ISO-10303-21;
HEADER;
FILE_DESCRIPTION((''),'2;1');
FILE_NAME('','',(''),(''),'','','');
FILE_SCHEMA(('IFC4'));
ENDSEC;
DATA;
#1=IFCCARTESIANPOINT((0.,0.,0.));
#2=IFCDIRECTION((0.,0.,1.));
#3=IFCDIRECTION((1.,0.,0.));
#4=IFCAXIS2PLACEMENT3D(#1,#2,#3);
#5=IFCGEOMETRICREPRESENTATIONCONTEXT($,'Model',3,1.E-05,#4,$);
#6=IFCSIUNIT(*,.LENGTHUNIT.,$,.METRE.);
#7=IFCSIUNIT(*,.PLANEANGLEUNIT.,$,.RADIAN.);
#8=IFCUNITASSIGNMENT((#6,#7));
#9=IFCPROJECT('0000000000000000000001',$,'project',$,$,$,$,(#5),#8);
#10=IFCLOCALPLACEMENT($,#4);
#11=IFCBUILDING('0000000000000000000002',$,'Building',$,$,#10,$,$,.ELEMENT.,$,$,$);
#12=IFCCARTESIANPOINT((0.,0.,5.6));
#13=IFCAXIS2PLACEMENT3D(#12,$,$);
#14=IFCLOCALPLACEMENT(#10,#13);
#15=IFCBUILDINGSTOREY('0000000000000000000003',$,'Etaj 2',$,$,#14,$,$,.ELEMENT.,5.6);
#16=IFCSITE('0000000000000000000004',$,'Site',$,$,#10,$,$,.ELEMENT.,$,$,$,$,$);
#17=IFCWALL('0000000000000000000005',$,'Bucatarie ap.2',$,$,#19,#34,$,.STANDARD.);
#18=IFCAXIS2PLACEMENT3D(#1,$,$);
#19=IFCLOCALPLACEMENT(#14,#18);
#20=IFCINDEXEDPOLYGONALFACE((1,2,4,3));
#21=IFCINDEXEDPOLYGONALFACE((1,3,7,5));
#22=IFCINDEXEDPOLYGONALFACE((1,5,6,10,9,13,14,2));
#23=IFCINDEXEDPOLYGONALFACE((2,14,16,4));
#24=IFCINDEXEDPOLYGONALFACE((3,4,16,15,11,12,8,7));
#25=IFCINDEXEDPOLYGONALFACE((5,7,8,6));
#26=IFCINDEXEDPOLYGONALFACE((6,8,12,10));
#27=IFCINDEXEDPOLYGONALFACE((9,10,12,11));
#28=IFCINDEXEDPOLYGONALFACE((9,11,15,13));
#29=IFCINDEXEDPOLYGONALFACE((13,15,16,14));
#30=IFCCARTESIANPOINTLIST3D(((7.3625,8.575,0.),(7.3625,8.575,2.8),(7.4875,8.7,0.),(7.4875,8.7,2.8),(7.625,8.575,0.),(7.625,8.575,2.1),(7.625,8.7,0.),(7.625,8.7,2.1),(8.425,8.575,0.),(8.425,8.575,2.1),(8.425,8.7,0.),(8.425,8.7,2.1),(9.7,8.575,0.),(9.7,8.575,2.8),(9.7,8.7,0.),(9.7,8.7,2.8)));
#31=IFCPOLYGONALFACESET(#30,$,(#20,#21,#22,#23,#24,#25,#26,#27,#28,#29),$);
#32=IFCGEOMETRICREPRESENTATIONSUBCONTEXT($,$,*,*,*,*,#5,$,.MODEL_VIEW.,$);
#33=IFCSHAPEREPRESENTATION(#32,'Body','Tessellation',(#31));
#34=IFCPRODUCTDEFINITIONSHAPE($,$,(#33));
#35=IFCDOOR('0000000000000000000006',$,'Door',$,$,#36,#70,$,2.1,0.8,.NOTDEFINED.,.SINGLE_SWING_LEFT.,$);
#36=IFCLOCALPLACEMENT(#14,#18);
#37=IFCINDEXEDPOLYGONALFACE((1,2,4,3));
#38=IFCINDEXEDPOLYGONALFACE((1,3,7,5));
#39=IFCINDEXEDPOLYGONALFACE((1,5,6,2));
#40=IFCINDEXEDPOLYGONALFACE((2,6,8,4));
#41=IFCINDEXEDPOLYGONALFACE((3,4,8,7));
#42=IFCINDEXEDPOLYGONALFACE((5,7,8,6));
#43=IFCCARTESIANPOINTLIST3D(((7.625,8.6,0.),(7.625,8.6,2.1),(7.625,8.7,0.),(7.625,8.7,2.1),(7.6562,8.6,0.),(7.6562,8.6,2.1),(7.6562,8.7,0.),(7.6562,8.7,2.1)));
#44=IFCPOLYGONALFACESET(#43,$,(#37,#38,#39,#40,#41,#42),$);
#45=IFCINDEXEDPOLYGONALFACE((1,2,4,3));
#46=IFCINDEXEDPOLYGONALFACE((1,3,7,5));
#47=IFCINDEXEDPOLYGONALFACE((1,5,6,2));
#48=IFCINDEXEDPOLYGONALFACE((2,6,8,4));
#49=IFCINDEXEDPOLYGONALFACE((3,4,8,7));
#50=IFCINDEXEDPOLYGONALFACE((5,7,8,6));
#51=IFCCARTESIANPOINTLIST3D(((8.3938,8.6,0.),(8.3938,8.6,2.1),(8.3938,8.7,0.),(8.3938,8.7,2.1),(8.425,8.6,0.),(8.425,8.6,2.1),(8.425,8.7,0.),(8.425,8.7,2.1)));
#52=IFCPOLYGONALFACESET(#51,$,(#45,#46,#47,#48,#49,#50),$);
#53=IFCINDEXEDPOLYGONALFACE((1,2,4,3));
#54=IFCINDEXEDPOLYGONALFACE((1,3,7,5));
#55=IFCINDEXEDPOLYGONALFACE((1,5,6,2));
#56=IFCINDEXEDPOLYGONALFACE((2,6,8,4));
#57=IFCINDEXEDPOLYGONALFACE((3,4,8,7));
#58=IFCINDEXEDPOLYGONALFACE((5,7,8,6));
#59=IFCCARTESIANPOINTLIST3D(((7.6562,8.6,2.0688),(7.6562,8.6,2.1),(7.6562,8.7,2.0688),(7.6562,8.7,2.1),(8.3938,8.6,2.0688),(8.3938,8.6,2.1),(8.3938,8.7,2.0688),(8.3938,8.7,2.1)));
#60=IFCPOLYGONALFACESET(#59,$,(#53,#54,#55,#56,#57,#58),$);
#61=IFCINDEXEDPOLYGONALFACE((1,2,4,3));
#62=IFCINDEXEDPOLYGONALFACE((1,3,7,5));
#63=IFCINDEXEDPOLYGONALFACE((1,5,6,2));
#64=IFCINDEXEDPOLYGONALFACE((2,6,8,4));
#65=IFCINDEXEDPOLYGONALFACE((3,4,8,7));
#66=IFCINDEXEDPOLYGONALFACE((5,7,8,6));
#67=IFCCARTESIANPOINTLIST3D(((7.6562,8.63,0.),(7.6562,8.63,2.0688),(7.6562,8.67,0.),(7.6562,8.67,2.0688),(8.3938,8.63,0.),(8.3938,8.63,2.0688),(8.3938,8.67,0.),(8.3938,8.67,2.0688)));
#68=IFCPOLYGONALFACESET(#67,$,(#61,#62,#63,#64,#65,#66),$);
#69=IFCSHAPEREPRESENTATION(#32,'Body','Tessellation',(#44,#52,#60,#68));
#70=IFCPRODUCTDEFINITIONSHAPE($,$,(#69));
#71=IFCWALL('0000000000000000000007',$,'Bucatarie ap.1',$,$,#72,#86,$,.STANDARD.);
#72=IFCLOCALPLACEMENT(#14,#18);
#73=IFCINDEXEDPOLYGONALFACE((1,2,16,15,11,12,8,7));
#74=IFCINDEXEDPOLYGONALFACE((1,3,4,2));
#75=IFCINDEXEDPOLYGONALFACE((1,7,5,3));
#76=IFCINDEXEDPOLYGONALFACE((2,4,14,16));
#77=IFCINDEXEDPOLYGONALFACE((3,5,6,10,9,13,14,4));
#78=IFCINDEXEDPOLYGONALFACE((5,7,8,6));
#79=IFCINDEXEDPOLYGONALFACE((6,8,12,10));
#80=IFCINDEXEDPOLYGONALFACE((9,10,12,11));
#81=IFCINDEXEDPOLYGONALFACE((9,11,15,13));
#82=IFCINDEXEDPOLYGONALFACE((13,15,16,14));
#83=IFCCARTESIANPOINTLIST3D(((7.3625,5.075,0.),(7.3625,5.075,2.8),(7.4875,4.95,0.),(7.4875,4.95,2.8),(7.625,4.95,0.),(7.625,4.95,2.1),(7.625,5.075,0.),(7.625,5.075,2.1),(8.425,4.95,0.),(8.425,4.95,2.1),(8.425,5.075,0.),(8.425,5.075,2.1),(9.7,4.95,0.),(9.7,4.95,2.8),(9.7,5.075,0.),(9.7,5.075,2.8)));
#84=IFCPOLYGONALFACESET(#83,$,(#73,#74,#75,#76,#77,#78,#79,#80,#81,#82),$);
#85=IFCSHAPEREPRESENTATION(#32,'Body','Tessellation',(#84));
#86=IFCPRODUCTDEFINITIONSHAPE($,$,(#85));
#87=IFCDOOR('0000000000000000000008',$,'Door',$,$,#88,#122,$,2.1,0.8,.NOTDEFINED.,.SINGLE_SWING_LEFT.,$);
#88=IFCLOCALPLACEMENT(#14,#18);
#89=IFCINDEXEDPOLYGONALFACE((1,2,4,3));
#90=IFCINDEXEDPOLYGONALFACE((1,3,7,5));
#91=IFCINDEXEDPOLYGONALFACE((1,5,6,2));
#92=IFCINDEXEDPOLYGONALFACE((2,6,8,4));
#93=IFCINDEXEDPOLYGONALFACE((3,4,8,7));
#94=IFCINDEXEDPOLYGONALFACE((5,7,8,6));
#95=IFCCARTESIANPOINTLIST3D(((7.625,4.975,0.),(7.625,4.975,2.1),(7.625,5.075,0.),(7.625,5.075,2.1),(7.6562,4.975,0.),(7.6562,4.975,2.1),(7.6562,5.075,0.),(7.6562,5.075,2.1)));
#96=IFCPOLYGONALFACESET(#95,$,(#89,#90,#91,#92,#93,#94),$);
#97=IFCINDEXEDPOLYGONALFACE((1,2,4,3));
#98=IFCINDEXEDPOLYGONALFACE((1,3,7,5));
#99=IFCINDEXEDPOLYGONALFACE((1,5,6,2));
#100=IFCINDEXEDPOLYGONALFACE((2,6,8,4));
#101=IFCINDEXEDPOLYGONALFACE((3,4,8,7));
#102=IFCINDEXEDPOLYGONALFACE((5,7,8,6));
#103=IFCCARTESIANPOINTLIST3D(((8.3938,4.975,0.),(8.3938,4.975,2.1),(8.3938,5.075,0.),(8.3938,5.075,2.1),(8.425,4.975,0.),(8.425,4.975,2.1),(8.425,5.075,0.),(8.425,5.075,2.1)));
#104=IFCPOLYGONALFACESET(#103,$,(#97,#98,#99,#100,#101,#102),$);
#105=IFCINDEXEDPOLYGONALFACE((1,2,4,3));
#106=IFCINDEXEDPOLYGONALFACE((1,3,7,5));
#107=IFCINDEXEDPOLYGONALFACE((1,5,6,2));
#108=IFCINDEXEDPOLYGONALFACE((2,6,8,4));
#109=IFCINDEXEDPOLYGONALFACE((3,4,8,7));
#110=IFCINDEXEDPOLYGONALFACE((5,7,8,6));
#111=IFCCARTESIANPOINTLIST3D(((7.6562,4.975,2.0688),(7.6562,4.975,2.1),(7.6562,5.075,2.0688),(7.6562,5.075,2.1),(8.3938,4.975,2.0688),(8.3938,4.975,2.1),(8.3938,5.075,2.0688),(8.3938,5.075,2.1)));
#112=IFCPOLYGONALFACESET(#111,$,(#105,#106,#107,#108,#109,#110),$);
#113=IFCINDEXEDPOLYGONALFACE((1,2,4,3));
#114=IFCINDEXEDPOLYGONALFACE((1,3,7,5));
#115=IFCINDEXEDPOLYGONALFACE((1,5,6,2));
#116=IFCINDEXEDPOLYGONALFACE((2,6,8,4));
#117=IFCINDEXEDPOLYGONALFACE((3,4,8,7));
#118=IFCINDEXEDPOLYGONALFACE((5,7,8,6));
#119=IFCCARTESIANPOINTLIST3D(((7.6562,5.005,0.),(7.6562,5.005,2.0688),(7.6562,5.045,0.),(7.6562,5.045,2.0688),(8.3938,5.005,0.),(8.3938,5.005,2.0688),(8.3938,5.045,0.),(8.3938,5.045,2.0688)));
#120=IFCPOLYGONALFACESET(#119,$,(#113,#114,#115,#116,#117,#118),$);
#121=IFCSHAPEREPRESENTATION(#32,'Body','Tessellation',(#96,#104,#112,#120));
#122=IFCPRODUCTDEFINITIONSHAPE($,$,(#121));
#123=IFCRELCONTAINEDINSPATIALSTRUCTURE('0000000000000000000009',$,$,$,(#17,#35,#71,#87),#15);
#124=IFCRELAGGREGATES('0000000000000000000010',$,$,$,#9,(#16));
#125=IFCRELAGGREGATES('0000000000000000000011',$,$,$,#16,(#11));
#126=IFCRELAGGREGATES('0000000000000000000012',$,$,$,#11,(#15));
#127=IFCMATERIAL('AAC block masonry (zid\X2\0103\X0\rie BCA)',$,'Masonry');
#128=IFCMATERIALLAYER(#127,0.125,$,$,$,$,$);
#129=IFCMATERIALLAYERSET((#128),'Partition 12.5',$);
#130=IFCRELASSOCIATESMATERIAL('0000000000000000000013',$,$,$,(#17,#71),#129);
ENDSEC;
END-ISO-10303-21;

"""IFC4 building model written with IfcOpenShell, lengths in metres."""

from ifc_helpers import new_model, si_unit, frame, frame_2d, origin, origin_with_axes, origin_2d, place, context, subcontext, project, spatial, rectangle, extrude, clip, halfspace, material, layer, layer_set, layer_usage, element, fill, save


model = new_model("IFC4")

# Units and contexts
model_context = context("Model", 3, precision=1e-05, world=origin_with_axes())
sub_context = subcontext(model_context, None, None, "MODEL_VIEW")
ifc_project = project(units=[si_unit("LENGTHUNIT", "METRE"), si_unit("PLANEANGLEUNIT", "RADIAN")], contexts=[model_context])

# Site, building, storey
placement = place(None, origin_with_axes())
site = spatial("IfcSite", under=ifc_project, at=placement, Name="Site", CompositionType="ELEMENT")
building = spatial("IfcBuilding", under=site, at=placement, Name="Building", CompositionType="ELEMENT")
storey_placement = place(placement, frame((0.0, 0.0, 5.6)))
storey = spatial("IfcBuildingStorey", under=building, at=storey_placement, Name="Etaj 2", CompositionType="ELEMENT", Elevation=5.6)

# Shared definitions
ifc_material_1 = material(Name="AAC block masonry (zidărie BCA)", Category="Masonry")
ifc_layer_1 = layer(ifc_material_1, 0.125)
ifc_layer_set_1 = layer_set([ifc_layer_1], Name="Partition 12.5")
ifc_layer_usage_1 = layer_usage(ifc_layer_set_1, "AXIS2", "POSITIVE", -0.0625)

# Walls, openings, doors
wall_1_placement = place(storey_placement, frame((7.3625, 8.6375, 0.0), x_axis=(1.0, 0.0, 0.0)))
wall_1 = element("IfcWall", 1, at=wall_1_placement, inside=storey, material=ifc_layer_usage_1, Name="Bucatarie ap.2", PredefinedType="STANDARD", context=sub_context, shape_type="CSG", body=[
    clip(extrude(rectangle(XDim=2.3375, YDim=0.125, at=frame_2d((1.1688, 0.0))), origin(), (0.0, 0.0, 1.0), 2.8), halfspace(frame((0.0625, 0.0, 0.0), z_axis=(-0.707107, 0.707107, 0.0)), False)),
])
opening_1_placement = place(wall_1_placement, frame((0.6625, 0.1125, 0.0), z_axis=(0.0, -1.0, 0.0), x_axis=(1.0, 0.0, 0.0)))
opening_1 = element("IfcOpeningElement", 2, at=opening_1_placement, cuts=wall_1, PredefinedType="OPENING", context=sub_context, shape_type="SweptSolid", body=[
    extrude(rectangle(XDim=0.8, YDim=2.1, at=frame_2d((0.0, 1.05))), origin(), (0.0, 0.0, 1.0), 0.225),
])
door_1_placement = place(wall_1_placement, frame((0.6625, 0.0625, 0.0), z_axis=(0.0, -1.0, 0.0), x_axis=(1.0, 0.0, 0.0)))
door_1 = element("IfcDoor", 3, at=door_1_placement, inside=storey, Name="Door", OperationType="SINGLE_SWING_LEFT", OverallHeight=2.1, OverallWidth=0.8, PredefinedType="NOTDEFINED", context=sub_context, shape_type="SweptSolid", body=[
    extrude(rectangle(XDim=0.0312, YDim=2.1, at=origin_2d()), frame((-0.3844, 1.05, 0.0)), (0.0, 0.0, 1.0), 0.1),
    extrude(rectangle(XDim=0.0312, YDim=2.1, at=origin_2d()), frame((0.3844, 1.05, 0.0)), (0.0, 0.0, 1.0), 0.1),
    extrude(rectangle(XDim=0.7375, YDim=0.0312, at=origin_2d()), frame((0.0, 2.0844, 0.0)), (0.0, 0.0, 1.0), 0.1),
    extrude(rectangle(XDim=0.7375, YDim=2.0688, at=origin_2d()), frame((0.0, 1.0344, 0.03)), (0.0, 0.0, 1.0), 0.04),
])
fill(opening_1, door_1)
wall_2_placement = place(storey_placement, frame((7.3625, 5.0125, 0.0), x_axis=(1.0, 0.0, 0.0)))
wall_2 = element("IfcWall", 4, at=wall_2_placement, inside=storey, material=ifc_layer_usage_1, Name="Bucatarie ap.1", PredefinedType="STANDARD", context=sub_context, shape_type="CSG", body=[
    clip(extrude(rectangle(XDim=2.3375, YDim=0.125, at=frame_2d((1.1688, 0.0))), origin(), (0.0, 0.0, 1.0), 2.8), halfspace(frame((0.0625, 0.0, 0.0), z_axis=(-0.707107, -0.707107, 0.0)), False)),
])
opening_2_placement = place(wall_2_placement, frame((0.6625, 0.1125, 0.0), z_axis=(0.0, -1.0, 0.0), x_axis=(1.0, 0.0, 0.0)))
opening_2 = element("IfcOpeningElement", 5, at=opening_2_placement, cuts=wall_2, PredefinedType="OPENING", context=sub_context, shape_type="SweptSolid", body=[
    extrude(rectangle(XDim=0.8, YDim=2.1, at=frame_2d((0.0, 1.05))), origin(), (0.0, 0.0, 1.0), 0.225),
])
door_2_placement = place(wall_2_placement, frame((0.6625, 0.0625, 0.0), z_axis=(0.0, -1.0, 0.0), x_axis=(1.0, 0.0, 0.0)))
door_2 = element("IfcDoor", 6, at=door_2_placement, inside=storey, Name="Door", OperationType="SINGLE_SWING_LEFT", OverallHeight=2.1, OverallWidth=0.8, PredefinedType="NOTDEFINED", context=sub_context, shape_type="SweptSolid", body=[
    extrude(rectangle(XDim=0.0312, YDim=2.1, at=origin_2d()), frame((-0.3844, 1.05, 0.0)), (0.0, 0.0, 1.0), 0.1),
    extrude(rectangle(XDim=0.0312, YDim=2.1, at=origin_2d()), frame((0.3844, 1.05, 0.0)), (0.0, 0.0, 1.0), 0.1),
    extrude(rectangle(XDim=0.7375, YDim=0.0312, at=origin_2d()), frame((0.0, 2.0844, 0.0)), (0.0, 0.0, 1.0), 0.1),
    extrude(rectangle(XDim=0.7375, YDim=2.0688, at=origin_2d()), frame((0.0, 1.0344, 0.03)), (0.0, 0.0, 1.0), 0.04),
])
fill(opening_2, door_2)

save(model, "model.ifc")
